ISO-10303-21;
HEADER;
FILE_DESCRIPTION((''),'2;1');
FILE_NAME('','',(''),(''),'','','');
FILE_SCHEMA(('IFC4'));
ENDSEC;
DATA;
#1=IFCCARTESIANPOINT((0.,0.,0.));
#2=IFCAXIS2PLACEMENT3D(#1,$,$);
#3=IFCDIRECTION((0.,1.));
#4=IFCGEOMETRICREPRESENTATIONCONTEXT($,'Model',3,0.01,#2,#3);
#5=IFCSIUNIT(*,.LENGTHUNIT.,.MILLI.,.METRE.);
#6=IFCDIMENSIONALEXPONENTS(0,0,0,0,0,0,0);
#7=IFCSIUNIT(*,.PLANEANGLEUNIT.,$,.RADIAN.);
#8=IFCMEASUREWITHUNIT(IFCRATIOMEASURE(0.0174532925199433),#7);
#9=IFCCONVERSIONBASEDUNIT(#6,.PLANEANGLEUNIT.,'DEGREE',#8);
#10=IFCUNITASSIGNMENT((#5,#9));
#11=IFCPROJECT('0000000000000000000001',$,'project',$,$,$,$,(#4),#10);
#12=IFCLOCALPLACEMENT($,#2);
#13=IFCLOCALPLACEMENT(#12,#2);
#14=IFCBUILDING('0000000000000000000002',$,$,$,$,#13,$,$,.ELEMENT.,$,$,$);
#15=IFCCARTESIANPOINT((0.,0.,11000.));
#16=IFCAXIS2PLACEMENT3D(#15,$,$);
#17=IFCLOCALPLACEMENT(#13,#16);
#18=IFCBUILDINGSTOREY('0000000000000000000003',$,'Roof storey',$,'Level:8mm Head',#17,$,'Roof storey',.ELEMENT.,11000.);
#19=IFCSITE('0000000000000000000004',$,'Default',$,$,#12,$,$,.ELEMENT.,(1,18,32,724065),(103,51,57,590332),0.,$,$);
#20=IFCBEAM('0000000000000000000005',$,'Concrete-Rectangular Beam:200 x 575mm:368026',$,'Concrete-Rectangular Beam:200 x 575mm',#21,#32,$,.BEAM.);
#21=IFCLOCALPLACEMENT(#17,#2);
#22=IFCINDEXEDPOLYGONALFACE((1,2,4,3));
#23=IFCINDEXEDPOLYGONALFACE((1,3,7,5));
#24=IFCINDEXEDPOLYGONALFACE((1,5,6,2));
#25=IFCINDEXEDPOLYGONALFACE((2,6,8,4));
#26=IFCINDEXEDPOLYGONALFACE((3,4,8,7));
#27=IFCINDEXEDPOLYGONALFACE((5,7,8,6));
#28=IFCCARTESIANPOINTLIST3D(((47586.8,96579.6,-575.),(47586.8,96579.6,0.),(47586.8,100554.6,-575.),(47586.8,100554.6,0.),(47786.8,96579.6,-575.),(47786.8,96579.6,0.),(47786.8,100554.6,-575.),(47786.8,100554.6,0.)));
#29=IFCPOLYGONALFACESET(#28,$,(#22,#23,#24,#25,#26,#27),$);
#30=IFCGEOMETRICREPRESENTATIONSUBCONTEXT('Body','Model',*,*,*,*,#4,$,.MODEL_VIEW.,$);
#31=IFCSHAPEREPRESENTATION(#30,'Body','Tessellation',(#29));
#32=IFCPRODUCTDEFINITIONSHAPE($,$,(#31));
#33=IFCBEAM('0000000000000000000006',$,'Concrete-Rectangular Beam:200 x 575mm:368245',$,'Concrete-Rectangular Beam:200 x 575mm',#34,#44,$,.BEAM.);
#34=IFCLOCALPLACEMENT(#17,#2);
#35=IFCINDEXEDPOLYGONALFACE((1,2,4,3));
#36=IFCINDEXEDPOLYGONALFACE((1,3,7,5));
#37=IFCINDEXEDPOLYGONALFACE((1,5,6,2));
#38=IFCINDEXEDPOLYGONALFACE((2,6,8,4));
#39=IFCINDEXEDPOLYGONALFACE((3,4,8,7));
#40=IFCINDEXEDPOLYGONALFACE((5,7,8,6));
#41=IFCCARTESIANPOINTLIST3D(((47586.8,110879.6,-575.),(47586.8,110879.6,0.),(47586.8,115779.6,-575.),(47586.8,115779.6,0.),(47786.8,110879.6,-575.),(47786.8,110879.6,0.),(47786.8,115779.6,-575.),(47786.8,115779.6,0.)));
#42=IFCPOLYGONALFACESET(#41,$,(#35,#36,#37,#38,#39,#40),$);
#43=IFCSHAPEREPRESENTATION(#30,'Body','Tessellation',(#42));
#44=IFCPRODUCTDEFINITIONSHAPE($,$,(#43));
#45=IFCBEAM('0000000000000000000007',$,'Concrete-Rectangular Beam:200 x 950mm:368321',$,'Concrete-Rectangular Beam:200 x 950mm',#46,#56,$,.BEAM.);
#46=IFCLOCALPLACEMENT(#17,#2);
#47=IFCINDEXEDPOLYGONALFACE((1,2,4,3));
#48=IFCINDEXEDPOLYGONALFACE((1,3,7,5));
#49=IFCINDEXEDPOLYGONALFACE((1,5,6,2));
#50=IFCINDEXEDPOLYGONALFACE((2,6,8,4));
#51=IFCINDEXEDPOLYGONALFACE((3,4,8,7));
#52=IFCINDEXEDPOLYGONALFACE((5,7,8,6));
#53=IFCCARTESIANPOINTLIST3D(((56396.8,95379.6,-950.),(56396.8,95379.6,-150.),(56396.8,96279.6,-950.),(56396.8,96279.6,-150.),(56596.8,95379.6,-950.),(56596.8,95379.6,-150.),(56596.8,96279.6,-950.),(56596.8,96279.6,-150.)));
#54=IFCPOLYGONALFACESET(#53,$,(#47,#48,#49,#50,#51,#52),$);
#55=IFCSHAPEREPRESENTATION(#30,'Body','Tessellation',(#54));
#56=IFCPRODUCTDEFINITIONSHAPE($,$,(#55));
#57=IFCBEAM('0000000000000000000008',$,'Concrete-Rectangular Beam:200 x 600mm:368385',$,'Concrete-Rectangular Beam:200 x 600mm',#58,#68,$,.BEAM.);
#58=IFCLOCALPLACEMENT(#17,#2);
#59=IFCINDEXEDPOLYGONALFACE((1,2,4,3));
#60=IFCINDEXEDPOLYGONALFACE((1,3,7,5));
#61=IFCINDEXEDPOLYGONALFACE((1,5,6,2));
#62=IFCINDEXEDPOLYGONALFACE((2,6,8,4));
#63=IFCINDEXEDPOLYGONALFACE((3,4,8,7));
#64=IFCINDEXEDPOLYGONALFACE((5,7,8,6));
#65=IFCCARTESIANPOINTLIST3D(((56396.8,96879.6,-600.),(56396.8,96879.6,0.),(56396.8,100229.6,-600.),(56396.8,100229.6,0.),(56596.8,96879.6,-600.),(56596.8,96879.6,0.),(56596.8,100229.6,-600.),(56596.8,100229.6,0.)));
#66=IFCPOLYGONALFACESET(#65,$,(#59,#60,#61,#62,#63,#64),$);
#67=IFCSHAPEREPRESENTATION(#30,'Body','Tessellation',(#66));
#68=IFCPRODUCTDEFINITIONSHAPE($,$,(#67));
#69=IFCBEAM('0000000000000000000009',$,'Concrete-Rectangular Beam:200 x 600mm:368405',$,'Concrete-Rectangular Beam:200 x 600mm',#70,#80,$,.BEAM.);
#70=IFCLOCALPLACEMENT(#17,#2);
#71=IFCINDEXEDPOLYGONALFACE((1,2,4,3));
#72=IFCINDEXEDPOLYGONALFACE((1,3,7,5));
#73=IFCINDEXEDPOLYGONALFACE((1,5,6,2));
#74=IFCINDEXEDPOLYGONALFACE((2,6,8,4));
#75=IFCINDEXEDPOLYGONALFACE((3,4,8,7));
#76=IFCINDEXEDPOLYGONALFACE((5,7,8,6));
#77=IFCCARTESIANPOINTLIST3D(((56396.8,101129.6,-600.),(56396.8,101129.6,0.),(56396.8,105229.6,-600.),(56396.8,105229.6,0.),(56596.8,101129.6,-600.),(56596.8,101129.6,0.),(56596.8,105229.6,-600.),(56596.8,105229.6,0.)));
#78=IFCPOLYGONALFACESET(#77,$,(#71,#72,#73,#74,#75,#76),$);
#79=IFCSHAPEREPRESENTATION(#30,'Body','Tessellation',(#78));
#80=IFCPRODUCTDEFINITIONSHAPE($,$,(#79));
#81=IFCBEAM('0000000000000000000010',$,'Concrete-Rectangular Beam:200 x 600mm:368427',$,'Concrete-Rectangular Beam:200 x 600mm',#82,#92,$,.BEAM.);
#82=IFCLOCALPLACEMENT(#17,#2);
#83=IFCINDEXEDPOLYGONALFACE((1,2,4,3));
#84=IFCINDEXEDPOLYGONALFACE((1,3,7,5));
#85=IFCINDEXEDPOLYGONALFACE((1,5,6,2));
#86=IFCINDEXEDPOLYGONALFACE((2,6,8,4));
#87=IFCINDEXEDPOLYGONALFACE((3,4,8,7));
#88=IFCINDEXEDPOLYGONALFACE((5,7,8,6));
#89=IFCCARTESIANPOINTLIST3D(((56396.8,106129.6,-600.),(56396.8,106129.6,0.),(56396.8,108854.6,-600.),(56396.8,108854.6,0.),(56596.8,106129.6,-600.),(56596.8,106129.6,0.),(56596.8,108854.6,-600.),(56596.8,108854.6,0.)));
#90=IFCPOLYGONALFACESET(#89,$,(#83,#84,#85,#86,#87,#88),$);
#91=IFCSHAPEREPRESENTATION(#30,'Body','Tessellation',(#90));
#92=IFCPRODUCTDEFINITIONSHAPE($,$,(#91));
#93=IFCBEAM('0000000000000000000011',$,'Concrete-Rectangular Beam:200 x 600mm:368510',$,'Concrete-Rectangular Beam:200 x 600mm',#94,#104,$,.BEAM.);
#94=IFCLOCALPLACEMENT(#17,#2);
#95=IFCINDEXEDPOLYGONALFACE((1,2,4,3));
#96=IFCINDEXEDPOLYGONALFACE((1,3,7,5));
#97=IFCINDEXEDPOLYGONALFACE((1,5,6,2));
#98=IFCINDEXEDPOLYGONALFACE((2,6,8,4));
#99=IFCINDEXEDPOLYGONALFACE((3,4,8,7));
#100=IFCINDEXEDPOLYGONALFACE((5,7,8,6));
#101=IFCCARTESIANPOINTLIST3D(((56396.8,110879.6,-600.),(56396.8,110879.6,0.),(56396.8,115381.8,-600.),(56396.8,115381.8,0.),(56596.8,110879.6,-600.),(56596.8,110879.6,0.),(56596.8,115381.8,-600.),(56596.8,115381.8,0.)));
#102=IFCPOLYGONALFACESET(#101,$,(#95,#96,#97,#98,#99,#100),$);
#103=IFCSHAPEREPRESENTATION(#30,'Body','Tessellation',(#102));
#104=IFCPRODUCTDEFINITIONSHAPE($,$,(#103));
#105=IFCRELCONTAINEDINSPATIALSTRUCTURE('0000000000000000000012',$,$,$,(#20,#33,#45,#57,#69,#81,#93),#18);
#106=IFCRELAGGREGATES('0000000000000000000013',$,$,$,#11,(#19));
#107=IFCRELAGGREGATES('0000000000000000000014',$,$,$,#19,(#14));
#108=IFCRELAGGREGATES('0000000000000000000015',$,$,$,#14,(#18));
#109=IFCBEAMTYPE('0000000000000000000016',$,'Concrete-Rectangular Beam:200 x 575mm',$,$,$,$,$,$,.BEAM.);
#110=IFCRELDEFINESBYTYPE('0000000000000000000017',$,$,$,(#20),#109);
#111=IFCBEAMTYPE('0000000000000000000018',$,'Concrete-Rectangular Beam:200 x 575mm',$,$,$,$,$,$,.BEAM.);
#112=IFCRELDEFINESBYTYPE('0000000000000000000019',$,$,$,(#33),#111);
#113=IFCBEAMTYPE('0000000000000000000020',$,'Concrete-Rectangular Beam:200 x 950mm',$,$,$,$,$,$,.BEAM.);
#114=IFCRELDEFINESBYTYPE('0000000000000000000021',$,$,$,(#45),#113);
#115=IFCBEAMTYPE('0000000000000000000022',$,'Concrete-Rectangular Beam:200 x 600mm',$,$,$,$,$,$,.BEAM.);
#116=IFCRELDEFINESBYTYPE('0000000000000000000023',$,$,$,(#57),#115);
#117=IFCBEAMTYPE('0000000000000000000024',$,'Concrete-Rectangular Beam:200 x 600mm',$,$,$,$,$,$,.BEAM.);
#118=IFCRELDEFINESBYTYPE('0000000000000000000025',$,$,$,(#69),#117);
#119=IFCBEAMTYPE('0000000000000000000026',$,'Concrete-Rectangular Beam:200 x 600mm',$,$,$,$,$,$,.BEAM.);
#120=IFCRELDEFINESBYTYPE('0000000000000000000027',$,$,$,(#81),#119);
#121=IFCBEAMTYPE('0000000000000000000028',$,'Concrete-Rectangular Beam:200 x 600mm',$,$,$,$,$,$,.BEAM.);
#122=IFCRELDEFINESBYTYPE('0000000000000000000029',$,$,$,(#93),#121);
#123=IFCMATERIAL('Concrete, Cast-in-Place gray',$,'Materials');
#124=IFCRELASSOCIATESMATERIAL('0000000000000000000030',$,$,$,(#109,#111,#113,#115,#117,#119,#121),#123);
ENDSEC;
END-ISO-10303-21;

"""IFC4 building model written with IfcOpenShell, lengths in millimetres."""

from ifc_helpers import new_model, entity, si_unit, converted_unit, direction, frame, origin, place, context, subcontext, project, spatial, indexed_curve, outline, extrude, source, transform, mapped, material, type_object, type_shapes, element, save


model = new_model("IFC4")

# Units and contexts
model_context = context("Model", 3, precision=0.01, world=origin(), true_north=direction((0.0, 1.0)))
body_context = subcontext(model_context, "Body", "Model", "MODEL_VIEW")
ifc_project = project(units=[si_unit("LENGTHUNIT", "METRE", prefix="MILLI"), converted_unit("PLANEANGLEUNIT", "DEGREE", entity("IfcRatioMeasure", 0.0174532925199433), si_unit("PLANEANGLEUNIT", "RADIAN"), dimensions=[0, 0, 0, 0, 0, 0, 0])], contexts=[model_context])

# Site, building, storey
site_placement = place(None, origin())
site = spatial("IfcSite", under=ifc_project, at=site_placement, Name="Default", CompositionType="ELEMENT", RefLatitude=(1, 18, 32, 724065), RefLongitude=(103, 51, 57, 590332), RefElevation=0.0)
building_placement = place(site_placement, origin())
building = spatial("IfcBuilding", under=site, at=building_placement, CompositionType="ELEMENT")
storey_placement = place(building_placement, frame((0.0, 0.0, 11000.0)))
storey = spatial("IfcBuildingStorey", under=building, at=storey_placement, Name="Roof storey", ObjectType="Level:8mm Head", LongName="Roof storey", CompositionType="ELEMENT", Elevation=11000.0)

# Beams
ifc_material_1 = material(Name="Concrete, Cast-in-Place gray", Category="Materials")
beam_type_1 = type_object("IfcBeamType", Name="Concrete-Rectangular Beam:200 x 575mm", PredefinedType="BEAM", material=ifc_material_1)
shared_shape_1 = source(origin(), body_context, "Body", "SweptSolid", [
    extrude(outline(indexed_curve([(-100.0, -287.5), (100.0, -287.5), (100.0, 287.5), (-100.0, 287.5), (-100.0, -287.5)], self_intersect=False)), frame((47686.8, 96579.6, 10712.5), z_axis=(0.0, 1.0, 0.0), x_axis=(-1.0, 0.0, 0.0)), (0.0, 0.0, 1.0), 3975.0),
])
type_shapes(beam_type_1, [shared_shape_1])
beam_1_placement = place(storey_placement, frame((0.0, 0.0, -11000.0)))
element("IfcBeam", 1, at=beam_1_placement, inside=storey, type_object=beam_type_1, Name="Concrete-Rectangular Beam:200 x 575mm:368026", ObjectType="Concrete-Rectangular Beam:200 x 575mm", PredefinedType="BEAM", context=body_context, shape_type="MappedRepresentation", body=[
    mapped(shared_shape_1, transform((0.0, 0.0, 0.0), scale=1.0)),
])
beam_type_2 = type_object("IfcBeamType", Name="Concrete-Rectangular Beam:200 x 575mm", PredefinedType="BEAM", material=ifc_material_1)
shared_shape_2 = source(origin(), body_context, "Body", "SweptSolid", [
    extrude(outline(indexed_curve([(-100.0, -287.5), (100.0, -287.5), (100.0, 287.5), (-100.0, 287.5), (-100.0, -287.5)], self_intersect=False)), frame((47686.8, 110879.6, 10712.5), z_axis=(0.0, 1.0, 0.0), x_axis=(-1.0, 0.0, 0.0)), (0.0, 0.0, 1.0), 4900.0),
])
type_shapes(beam_type_2, [shared_shape_2])
beam_2_placement = place(storey_placement, frame((0.0, 0.0, -11000.0)))
element("IfcBeam", 2, at=beam_2_placement, inside=storey, type_object=beam_type_2, Name="Concrete-Rectangular Beam:200 x 575mm:368245", ObjectType="Concrete-Rectangular Beam:200 x 575mm", PredefinedType="BEAM", context=body_context, shape_type="MappedRepresentation", body=[
    mapped(shared_shape_2, transform((0.0, 0.0, 0.0), scale=1.0)),
])
beam_type_3 = type_object("IfcBeamType", Name="Concrete-Rectangular Beam:200 x 950mm", PredefinedType="BEAM", material=ifc_material_1)
shared_shape_3 = source(origin(), body_context, "Body", "SweptSolid", [
    extrude(outline(indexed_curve([(-100.0, -400.0), (100.0, -400.0), (100.0, 400.0), (-100.0, 400.0), (-100.0, -400.0)], self_intersect=False)), frame((56496.8, 95379.6, 10450.0), z_axis=(0.0, 1.0, 0.0), x_axis=(-1.0, 0.0, 0.0)), (0.0, 0.0, 1.0), 900.0),
])
type_shapes(beam_type_3, [shared_shape_3])
beam_3_placement = place(storey_placement, frame((0.0, 0.0, -11000.0)))
element("IfcBeam", 3, at=beam_3_placement, inside=storey, type_object=beam_type_3, Name="Concrete-Rectangular Beam:200 x 950mm:368321", ObjectType="Concrete-Rectangular Beam:200 x 950mm", PredefinedType="BEAM", context=body_context, shape_type="MappedRepresentation", body=[
    mapped(shared_shape_3, transform((0.0, 0.0, 0.0), scale=1.0)),
])
beam_type_4 = type_object("IfcBeamType", Name="Concrete-Rectangular Beam:200 x 600mm", PredefinedType="BEAM", material=ifc_material_1)
shared_shape_4 = source(origin(), body_context, "Body", "SweptSolid", [
    extrude(outline(indexed_curve([(-100.0, -300.0), (100.0, -300.0), (100.0, 300.0), (-100.0, 300.0), (-100.0, -300.0)], self_intersect=False)), frame((56496.8, 96879.6, 10700.0), z_axis=(0.0, 1.0, 0.0), x_axis=(-1.0, 0.0, 0.0)), (0.0, 0.0, 1.0), 3350.0),
])
type_shapes(beam_type_4, [shared_shape_4])
beam_4_placement = place(storey_placement, frame((0.0, 0.0, -11000.0)))
element("IfcBeam", 4, at=beam_4_placement, inside=storey, type_object=beam_type_4, Name="Concrete-Rectangular Beam:200 x 600mm:368385", ObjectType="Concrete-Rectangular Beam:200 x 600mm", PredefinedType="BEAM", context=body_context, shape_type="MappedRepresentation", body=[
    mapped(shared_shape_4, transform((0.0, 0.0, 0.0), scale=1.0)),
])
beam_type_5 = type_object("IfcBeamType", Name="Concrete-Rectangular Beam:200 x 600mm", PredefinedType="BEAM", material=ifc_material_1)
shared_shape_5 = source(origin(), body_context, "Body", "SweptSolid", [
    extrude(outline(indexed_curve([(-100.0, -300.0), (100.0, -300.0), (100.0, 300.0), (-100.0, 300.0), (-100.0, -300.0)], self_intersect=False)), frame((56496.8, 101129.6, 10700.0), z_axis=(0.0, 1.0, 0.0), x_axis=(-1.0, 0.0, 0.0)), (0.0, 0.0, 1.0), 4100.0),
])
type_shapes(beam_type_5, [shared_shape_5])
beam_5_placement = place(storey_placement, frame((0.0, 0.0, -11000.0)))
element("IfcBeam", 5, at=beam_5_placement, inside=storey, type_object=beam_type_5, Name="Concrete-Rectangular Beam:200 x 600mm:368405", ObjectType="Concrete-Rectangular Beam:200 x 600mm", PredefinedType="BEAM", context=body_context, shape_type="MappedRepresentation", body=[
    mapped(shared_shape_5, transform((0.0, 0.0, 0.0), scale=1.0)),
])
beam_type_6 = type_object("IfcBeamType", Name="Concrete-Rectangular Beam:200 x 600mm", PredefinedType="BEAM", material=ifc_material_1)
shared_shape_6 = source(origin(), body_context, "Body", "SweptSolid", [
    extrude(outline(indexed_curve([(-100.0, -300.0), (100.0, -300.0), (100.0, 300.0), (-100.0, 300.0), (-100.0, -300.0)], self_intersect=False)), frame((56496.8, 106129.6, 10700.0), z_axis=(0.0, 1.0, 0.0), x_axis=(-1.0, 0.0, 0.0)), (0.0, 0.0, 1.0), 2725.0),
])
type_shapes(beam_type_6, [shared_shape_6])
beam_6_placement = place(storey_placement, frame((0.0, 0.0, -11000.0)))
element("IfcBeam", 6, at=beam_6_placement, inside=storey, type_object=beam_type_6, Name="Concrete-Rectangular Beam:200 x 600mm:368427", ObjectType="Concrete-Rectangular Beam:200 x 600mm", PredefinedType="BEAM", context=body_context, shape_type="MappedRepresentation", body=[
    mapped(shared_shape_6, transform((0.0, 0.0, 0.0), scale=1.0)),
])
beam_type_7 = type_object("IfcBeamType", Name="Concrete-Rectangular Beam:200 x 600mm", PredefinedType="BEAM", material=ifc_material_1)
shared_shape_7 = source(origin(), body_context, "Body", "SweptSolid", [
    extrude(outline(indexed_curve([(-100.0, -300.0), (100.0, -300.0), (100.0, 300.0), (-100.0, 300.0), (-100.0, -300.0)], self_intersect=False)), frame((56496.8, 110879.6, 10700.0), z_axis=(0.0, 1.0, 0.0), x_axis=(-1.0, 0.0, 0.0)), (0.0, 0.0, 1.0), 4502.2),
])
type_shapes(beam_type_7, [shared_shape_7])
beam_7_placement = place(storey_placement, frame((0.0, 0.0, -11000.0)))
element("IfcBeam", 7, at=beam_7_placement, inside=storey, type_object=beam_type_7, Name="Concrete-Rectangular Beam:200 x 600mm:368510", ObjectType="Concrete-Rectangular Beam:200 x 600mm", PredefinedType="BEAM", context=body_context, shape_type="MappedRepresentation", body=[
    mapped(shared_shape_7, transform((0.0, 0.0, 0.0), scale=1.0)),
])

save(model, "model.ifc")
